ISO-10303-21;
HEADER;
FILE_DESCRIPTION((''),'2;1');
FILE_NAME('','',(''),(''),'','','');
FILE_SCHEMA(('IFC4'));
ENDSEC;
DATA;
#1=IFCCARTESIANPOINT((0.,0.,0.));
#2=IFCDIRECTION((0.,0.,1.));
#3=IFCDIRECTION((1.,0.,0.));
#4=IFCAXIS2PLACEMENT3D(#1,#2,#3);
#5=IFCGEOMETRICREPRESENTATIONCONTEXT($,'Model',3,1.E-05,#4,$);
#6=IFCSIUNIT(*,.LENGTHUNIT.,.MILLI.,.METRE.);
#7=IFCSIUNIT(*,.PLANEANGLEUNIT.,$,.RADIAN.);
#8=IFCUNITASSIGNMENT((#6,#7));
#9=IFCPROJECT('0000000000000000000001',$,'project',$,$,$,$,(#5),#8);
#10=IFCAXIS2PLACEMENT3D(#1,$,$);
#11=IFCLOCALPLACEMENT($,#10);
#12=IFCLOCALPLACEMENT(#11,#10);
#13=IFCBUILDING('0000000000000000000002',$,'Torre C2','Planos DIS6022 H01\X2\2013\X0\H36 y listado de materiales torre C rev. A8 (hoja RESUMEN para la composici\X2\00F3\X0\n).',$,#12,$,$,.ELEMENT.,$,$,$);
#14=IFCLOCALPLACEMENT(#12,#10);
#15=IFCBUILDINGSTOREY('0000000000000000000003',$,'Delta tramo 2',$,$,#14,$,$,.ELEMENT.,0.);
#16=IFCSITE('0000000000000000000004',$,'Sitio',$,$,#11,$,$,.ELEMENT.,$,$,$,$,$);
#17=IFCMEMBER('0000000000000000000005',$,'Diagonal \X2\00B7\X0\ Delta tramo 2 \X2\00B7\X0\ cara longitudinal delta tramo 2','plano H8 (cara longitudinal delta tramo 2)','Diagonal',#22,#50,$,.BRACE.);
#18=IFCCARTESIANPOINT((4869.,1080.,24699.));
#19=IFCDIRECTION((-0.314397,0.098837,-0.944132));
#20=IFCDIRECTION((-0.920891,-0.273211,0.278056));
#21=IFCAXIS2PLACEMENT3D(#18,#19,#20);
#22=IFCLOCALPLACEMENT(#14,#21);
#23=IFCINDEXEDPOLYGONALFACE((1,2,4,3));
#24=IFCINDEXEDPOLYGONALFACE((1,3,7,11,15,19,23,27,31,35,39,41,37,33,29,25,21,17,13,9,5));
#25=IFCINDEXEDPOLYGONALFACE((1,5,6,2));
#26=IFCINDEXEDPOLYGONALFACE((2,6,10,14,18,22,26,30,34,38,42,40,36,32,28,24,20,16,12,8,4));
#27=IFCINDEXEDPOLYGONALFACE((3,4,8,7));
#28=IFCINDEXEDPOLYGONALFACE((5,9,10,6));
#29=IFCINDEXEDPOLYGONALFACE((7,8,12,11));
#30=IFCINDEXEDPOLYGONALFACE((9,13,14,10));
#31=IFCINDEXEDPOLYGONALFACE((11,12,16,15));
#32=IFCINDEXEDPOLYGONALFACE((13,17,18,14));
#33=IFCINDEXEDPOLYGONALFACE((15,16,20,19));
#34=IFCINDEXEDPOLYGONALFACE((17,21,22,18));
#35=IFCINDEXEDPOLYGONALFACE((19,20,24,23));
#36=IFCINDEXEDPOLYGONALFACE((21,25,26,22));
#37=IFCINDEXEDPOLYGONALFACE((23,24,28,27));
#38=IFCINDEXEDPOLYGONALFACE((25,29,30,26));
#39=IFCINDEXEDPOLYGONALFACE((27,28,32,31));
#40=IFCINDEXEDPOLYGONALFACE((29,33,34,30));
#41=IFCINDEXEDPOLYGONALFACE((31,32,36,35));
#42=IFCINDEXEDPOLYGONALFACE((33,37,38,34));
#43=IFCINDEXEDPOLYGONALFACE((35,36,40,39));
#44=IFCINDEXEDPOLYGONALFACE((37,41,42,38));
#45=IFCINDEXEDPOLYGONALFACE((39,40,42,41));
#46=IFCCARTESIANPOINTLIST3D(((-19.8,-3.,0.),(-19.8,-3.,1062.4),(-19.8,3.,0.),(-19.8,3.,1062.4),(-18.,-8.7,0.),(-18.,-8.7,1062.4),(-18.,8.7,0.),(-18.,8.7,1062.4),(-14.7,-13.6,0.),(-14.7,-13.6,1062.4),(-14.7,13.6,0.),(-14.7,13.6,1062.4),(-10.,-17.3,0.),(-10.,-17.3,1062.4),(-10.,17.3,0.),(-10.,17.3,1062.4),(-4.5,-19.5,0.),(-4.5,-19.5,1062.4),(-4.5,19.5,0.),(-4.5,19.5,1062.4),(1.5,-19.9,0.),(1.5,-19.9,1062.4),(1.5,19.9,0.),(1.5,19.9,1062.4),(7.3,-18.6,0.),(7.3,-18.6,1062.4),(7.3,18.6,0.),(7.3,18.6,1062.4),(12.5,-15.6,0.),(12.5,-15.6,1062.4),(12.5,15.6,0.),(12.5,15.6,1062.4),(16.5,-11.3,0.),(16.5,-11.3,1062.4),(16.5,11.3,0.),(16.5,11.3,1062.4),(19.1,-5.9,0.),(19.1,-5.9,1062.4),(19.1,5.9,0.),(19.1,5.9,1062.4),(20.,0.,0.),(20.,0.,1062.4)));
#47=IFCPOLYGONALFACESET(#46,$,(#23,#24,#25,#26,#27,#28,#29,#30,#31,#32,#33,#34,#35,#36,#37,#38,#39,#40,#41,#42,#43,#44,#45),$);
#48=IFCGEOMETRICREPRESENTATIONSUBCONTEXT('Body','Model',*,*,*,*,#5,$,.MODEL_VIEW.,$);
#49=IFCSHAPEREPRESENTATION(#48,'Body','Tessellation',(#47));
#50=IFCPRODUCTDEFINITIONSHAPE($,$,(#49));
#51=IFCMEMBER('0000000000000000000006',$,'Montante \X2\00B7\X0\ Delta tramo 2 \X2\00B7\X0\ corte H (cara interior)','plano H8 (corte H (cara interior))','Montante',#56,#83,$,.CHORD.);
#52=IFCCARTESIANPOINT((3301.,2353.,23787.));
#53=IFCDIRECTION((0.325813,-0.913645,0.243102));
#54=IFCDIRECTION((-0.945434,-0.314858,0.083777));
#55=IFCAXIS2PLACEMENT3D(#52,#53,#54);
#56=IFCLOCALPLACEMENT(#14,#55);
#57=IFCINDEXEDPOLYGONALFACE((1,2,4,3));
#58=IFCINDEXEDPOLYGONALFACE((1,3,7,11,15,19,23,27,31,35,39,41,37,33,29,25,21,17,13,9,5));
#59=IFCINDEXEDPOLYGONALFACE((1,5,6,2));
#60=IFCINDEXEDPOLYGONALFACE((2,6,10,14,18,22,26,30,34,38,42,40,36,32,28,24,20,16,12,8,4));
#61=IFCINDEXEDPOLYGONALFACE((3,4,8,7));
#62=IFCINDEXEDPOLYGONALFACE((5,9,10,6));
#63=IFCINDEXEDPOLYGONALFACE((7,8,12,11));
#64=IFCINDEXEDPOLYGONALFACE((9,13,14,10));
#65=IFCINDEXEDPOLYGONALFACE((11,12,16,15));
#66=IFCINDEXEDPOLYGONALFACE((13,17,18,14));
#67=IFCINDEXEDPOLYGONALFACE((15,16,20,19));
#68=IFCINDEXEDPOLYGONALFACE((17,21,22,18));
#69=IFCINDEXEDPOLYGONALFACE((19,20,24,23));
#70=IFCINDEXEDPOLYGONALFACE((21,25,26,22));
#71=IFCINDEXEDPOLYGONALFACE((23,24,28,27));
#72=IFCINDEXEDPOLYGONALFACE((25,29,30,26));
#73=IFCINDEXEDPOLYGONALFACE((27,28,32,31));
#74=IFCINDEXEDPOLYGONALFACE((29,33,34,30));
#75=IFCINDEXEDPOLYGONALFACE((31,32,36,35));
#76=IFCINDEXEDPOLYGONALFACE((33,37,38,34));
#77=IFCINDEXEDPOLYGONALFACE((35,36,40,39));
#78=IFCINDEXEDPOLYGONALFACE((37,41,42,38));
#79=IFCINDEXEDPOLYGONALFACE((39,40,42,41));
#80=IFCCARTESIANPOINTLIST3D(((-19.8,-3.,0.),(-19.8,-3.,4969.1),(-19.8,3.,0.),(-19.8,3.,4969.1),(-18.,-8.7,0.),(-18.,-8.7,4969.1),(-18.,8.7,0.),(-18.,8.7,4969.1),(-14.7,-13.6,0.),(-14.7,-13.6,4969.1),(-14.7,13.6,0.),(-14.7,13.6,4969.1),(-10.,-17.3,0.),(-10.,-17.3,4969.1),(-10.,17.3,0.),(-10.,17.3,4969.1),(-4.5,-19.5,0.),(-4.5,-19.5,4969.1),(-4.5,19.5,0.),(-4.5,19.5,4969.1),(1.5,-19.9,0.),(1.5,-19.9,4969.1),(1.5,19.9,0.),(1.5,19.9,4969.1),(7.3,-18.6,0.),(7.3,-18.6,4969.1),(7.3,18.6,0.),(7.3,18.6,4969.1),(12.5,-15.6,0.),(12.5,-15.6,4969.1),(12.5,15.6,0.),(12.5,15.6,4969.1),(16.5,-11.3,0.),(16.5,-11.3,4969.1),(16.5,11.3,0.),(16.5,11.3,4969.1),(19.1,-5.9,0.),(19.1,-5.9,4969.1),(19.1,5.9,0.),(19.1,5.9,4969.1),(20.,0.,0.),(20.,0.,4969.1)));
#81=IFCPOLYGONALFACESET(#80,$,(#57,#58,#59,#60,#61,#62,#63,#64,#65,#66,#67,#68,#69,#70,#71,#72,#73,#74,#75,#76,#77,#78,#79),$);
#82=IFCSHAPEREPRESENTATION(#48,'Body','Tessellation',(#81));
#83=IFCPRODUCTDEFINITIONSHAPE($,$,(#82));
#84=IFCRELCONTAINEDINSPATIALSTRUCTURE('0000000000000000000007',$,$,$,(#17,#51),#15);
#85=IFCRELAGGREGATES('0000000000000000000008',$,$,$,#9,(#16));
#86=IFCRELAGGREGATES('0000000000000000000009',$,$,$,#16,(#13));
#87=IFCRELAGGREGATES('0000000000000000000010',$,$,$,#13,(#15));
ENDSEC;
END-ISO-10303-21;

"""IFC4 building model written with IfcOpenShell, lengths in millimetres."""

from ifc_helpers import new_model, si_unit, frame, origin, origin_with_axes, place, context, subcontext, project, spatial, circle, extrude, element, save


model = new_model("IFC4")

# Units and contexts
model_context = context("Model", 3, precision=1e-05, world=origin_with_axes())
body_context = subcontext(model_context, "Body", "Model", "MODEL_VIEW")
ifc_project = project(units=[si_unit("LENGTHUNIT", "METRE", prefix="MILLI"), si_unit("PLANEANGLEUNIT", "RADIAN")], contexts=[model_context])

# Site, building, storey
site_placement = place(None, origin())
site = spatial("IfcSite", under=ifc_project, at=site_placement, Name="Sitio", CompositionType="ELEMENT")
building_placement = place(site_placement, origin())
building = spatial("IfcBuilding", under=site, at=building_placement, Name="Torre C2", Description="Planos DIS6022 H01–H36 y listado de materiales torre C rev. A8 (hoja RESUMEN para la composición).", CompositionType="ELEMENT")
storey_placement = place(building_placement, origin())
storey = spatial("IfcBuildingStorey", under=building, at=storey_placement, Name="Delta tramo 2", CompositionType="ELEMENT", Elevation=0.0)

# Members
member_1_placement = place(storey_placement, frame((4869.0, 1080.0, 24699.0), z_axis=(-0.314397, 0.098837, -0.944132), x_axis=(-0.920891, -0.273211, 0.278056)))
element("IfcMember", 1, at=member_1_placement, inside=storey, Name="Diagonal · Delta tramo 2 · cara longitudinal delta tramo 2", Description="plano H8 (cara longitudinal delta tramo 2)", ObjectType="Diagonal", PredefinedType="BRACE", context=body_context, shape_type="SweptSolid", body=[
    extrude(circle(Radius=20.0), None, (0.0, 0.0, 1.0), 1062.4),
])
member_2_placement = place(storey_placement, frame((3301.0, 2353.0, 23787.0), z_axis=(0.325813, -0.913645, 0.243102), x_axis=(-0.945434, -0.314858, 0.083777)))
element("IfcMember", 2, at=member_2_placement, inside=storey, Name="Montante · Delta tramo 2 · corte H (cara interior)", Description="plano H8 (corte H (cara interior))", ObjectType="Montante", PredefinedType="CHORD", context=body_context, shape_type="SweptSolid", body=[
    extrude(circle(Radius=20.0), None, (0.0, 0.0, 1.0), 4969.1),
])

save(model, "model.ifc")
